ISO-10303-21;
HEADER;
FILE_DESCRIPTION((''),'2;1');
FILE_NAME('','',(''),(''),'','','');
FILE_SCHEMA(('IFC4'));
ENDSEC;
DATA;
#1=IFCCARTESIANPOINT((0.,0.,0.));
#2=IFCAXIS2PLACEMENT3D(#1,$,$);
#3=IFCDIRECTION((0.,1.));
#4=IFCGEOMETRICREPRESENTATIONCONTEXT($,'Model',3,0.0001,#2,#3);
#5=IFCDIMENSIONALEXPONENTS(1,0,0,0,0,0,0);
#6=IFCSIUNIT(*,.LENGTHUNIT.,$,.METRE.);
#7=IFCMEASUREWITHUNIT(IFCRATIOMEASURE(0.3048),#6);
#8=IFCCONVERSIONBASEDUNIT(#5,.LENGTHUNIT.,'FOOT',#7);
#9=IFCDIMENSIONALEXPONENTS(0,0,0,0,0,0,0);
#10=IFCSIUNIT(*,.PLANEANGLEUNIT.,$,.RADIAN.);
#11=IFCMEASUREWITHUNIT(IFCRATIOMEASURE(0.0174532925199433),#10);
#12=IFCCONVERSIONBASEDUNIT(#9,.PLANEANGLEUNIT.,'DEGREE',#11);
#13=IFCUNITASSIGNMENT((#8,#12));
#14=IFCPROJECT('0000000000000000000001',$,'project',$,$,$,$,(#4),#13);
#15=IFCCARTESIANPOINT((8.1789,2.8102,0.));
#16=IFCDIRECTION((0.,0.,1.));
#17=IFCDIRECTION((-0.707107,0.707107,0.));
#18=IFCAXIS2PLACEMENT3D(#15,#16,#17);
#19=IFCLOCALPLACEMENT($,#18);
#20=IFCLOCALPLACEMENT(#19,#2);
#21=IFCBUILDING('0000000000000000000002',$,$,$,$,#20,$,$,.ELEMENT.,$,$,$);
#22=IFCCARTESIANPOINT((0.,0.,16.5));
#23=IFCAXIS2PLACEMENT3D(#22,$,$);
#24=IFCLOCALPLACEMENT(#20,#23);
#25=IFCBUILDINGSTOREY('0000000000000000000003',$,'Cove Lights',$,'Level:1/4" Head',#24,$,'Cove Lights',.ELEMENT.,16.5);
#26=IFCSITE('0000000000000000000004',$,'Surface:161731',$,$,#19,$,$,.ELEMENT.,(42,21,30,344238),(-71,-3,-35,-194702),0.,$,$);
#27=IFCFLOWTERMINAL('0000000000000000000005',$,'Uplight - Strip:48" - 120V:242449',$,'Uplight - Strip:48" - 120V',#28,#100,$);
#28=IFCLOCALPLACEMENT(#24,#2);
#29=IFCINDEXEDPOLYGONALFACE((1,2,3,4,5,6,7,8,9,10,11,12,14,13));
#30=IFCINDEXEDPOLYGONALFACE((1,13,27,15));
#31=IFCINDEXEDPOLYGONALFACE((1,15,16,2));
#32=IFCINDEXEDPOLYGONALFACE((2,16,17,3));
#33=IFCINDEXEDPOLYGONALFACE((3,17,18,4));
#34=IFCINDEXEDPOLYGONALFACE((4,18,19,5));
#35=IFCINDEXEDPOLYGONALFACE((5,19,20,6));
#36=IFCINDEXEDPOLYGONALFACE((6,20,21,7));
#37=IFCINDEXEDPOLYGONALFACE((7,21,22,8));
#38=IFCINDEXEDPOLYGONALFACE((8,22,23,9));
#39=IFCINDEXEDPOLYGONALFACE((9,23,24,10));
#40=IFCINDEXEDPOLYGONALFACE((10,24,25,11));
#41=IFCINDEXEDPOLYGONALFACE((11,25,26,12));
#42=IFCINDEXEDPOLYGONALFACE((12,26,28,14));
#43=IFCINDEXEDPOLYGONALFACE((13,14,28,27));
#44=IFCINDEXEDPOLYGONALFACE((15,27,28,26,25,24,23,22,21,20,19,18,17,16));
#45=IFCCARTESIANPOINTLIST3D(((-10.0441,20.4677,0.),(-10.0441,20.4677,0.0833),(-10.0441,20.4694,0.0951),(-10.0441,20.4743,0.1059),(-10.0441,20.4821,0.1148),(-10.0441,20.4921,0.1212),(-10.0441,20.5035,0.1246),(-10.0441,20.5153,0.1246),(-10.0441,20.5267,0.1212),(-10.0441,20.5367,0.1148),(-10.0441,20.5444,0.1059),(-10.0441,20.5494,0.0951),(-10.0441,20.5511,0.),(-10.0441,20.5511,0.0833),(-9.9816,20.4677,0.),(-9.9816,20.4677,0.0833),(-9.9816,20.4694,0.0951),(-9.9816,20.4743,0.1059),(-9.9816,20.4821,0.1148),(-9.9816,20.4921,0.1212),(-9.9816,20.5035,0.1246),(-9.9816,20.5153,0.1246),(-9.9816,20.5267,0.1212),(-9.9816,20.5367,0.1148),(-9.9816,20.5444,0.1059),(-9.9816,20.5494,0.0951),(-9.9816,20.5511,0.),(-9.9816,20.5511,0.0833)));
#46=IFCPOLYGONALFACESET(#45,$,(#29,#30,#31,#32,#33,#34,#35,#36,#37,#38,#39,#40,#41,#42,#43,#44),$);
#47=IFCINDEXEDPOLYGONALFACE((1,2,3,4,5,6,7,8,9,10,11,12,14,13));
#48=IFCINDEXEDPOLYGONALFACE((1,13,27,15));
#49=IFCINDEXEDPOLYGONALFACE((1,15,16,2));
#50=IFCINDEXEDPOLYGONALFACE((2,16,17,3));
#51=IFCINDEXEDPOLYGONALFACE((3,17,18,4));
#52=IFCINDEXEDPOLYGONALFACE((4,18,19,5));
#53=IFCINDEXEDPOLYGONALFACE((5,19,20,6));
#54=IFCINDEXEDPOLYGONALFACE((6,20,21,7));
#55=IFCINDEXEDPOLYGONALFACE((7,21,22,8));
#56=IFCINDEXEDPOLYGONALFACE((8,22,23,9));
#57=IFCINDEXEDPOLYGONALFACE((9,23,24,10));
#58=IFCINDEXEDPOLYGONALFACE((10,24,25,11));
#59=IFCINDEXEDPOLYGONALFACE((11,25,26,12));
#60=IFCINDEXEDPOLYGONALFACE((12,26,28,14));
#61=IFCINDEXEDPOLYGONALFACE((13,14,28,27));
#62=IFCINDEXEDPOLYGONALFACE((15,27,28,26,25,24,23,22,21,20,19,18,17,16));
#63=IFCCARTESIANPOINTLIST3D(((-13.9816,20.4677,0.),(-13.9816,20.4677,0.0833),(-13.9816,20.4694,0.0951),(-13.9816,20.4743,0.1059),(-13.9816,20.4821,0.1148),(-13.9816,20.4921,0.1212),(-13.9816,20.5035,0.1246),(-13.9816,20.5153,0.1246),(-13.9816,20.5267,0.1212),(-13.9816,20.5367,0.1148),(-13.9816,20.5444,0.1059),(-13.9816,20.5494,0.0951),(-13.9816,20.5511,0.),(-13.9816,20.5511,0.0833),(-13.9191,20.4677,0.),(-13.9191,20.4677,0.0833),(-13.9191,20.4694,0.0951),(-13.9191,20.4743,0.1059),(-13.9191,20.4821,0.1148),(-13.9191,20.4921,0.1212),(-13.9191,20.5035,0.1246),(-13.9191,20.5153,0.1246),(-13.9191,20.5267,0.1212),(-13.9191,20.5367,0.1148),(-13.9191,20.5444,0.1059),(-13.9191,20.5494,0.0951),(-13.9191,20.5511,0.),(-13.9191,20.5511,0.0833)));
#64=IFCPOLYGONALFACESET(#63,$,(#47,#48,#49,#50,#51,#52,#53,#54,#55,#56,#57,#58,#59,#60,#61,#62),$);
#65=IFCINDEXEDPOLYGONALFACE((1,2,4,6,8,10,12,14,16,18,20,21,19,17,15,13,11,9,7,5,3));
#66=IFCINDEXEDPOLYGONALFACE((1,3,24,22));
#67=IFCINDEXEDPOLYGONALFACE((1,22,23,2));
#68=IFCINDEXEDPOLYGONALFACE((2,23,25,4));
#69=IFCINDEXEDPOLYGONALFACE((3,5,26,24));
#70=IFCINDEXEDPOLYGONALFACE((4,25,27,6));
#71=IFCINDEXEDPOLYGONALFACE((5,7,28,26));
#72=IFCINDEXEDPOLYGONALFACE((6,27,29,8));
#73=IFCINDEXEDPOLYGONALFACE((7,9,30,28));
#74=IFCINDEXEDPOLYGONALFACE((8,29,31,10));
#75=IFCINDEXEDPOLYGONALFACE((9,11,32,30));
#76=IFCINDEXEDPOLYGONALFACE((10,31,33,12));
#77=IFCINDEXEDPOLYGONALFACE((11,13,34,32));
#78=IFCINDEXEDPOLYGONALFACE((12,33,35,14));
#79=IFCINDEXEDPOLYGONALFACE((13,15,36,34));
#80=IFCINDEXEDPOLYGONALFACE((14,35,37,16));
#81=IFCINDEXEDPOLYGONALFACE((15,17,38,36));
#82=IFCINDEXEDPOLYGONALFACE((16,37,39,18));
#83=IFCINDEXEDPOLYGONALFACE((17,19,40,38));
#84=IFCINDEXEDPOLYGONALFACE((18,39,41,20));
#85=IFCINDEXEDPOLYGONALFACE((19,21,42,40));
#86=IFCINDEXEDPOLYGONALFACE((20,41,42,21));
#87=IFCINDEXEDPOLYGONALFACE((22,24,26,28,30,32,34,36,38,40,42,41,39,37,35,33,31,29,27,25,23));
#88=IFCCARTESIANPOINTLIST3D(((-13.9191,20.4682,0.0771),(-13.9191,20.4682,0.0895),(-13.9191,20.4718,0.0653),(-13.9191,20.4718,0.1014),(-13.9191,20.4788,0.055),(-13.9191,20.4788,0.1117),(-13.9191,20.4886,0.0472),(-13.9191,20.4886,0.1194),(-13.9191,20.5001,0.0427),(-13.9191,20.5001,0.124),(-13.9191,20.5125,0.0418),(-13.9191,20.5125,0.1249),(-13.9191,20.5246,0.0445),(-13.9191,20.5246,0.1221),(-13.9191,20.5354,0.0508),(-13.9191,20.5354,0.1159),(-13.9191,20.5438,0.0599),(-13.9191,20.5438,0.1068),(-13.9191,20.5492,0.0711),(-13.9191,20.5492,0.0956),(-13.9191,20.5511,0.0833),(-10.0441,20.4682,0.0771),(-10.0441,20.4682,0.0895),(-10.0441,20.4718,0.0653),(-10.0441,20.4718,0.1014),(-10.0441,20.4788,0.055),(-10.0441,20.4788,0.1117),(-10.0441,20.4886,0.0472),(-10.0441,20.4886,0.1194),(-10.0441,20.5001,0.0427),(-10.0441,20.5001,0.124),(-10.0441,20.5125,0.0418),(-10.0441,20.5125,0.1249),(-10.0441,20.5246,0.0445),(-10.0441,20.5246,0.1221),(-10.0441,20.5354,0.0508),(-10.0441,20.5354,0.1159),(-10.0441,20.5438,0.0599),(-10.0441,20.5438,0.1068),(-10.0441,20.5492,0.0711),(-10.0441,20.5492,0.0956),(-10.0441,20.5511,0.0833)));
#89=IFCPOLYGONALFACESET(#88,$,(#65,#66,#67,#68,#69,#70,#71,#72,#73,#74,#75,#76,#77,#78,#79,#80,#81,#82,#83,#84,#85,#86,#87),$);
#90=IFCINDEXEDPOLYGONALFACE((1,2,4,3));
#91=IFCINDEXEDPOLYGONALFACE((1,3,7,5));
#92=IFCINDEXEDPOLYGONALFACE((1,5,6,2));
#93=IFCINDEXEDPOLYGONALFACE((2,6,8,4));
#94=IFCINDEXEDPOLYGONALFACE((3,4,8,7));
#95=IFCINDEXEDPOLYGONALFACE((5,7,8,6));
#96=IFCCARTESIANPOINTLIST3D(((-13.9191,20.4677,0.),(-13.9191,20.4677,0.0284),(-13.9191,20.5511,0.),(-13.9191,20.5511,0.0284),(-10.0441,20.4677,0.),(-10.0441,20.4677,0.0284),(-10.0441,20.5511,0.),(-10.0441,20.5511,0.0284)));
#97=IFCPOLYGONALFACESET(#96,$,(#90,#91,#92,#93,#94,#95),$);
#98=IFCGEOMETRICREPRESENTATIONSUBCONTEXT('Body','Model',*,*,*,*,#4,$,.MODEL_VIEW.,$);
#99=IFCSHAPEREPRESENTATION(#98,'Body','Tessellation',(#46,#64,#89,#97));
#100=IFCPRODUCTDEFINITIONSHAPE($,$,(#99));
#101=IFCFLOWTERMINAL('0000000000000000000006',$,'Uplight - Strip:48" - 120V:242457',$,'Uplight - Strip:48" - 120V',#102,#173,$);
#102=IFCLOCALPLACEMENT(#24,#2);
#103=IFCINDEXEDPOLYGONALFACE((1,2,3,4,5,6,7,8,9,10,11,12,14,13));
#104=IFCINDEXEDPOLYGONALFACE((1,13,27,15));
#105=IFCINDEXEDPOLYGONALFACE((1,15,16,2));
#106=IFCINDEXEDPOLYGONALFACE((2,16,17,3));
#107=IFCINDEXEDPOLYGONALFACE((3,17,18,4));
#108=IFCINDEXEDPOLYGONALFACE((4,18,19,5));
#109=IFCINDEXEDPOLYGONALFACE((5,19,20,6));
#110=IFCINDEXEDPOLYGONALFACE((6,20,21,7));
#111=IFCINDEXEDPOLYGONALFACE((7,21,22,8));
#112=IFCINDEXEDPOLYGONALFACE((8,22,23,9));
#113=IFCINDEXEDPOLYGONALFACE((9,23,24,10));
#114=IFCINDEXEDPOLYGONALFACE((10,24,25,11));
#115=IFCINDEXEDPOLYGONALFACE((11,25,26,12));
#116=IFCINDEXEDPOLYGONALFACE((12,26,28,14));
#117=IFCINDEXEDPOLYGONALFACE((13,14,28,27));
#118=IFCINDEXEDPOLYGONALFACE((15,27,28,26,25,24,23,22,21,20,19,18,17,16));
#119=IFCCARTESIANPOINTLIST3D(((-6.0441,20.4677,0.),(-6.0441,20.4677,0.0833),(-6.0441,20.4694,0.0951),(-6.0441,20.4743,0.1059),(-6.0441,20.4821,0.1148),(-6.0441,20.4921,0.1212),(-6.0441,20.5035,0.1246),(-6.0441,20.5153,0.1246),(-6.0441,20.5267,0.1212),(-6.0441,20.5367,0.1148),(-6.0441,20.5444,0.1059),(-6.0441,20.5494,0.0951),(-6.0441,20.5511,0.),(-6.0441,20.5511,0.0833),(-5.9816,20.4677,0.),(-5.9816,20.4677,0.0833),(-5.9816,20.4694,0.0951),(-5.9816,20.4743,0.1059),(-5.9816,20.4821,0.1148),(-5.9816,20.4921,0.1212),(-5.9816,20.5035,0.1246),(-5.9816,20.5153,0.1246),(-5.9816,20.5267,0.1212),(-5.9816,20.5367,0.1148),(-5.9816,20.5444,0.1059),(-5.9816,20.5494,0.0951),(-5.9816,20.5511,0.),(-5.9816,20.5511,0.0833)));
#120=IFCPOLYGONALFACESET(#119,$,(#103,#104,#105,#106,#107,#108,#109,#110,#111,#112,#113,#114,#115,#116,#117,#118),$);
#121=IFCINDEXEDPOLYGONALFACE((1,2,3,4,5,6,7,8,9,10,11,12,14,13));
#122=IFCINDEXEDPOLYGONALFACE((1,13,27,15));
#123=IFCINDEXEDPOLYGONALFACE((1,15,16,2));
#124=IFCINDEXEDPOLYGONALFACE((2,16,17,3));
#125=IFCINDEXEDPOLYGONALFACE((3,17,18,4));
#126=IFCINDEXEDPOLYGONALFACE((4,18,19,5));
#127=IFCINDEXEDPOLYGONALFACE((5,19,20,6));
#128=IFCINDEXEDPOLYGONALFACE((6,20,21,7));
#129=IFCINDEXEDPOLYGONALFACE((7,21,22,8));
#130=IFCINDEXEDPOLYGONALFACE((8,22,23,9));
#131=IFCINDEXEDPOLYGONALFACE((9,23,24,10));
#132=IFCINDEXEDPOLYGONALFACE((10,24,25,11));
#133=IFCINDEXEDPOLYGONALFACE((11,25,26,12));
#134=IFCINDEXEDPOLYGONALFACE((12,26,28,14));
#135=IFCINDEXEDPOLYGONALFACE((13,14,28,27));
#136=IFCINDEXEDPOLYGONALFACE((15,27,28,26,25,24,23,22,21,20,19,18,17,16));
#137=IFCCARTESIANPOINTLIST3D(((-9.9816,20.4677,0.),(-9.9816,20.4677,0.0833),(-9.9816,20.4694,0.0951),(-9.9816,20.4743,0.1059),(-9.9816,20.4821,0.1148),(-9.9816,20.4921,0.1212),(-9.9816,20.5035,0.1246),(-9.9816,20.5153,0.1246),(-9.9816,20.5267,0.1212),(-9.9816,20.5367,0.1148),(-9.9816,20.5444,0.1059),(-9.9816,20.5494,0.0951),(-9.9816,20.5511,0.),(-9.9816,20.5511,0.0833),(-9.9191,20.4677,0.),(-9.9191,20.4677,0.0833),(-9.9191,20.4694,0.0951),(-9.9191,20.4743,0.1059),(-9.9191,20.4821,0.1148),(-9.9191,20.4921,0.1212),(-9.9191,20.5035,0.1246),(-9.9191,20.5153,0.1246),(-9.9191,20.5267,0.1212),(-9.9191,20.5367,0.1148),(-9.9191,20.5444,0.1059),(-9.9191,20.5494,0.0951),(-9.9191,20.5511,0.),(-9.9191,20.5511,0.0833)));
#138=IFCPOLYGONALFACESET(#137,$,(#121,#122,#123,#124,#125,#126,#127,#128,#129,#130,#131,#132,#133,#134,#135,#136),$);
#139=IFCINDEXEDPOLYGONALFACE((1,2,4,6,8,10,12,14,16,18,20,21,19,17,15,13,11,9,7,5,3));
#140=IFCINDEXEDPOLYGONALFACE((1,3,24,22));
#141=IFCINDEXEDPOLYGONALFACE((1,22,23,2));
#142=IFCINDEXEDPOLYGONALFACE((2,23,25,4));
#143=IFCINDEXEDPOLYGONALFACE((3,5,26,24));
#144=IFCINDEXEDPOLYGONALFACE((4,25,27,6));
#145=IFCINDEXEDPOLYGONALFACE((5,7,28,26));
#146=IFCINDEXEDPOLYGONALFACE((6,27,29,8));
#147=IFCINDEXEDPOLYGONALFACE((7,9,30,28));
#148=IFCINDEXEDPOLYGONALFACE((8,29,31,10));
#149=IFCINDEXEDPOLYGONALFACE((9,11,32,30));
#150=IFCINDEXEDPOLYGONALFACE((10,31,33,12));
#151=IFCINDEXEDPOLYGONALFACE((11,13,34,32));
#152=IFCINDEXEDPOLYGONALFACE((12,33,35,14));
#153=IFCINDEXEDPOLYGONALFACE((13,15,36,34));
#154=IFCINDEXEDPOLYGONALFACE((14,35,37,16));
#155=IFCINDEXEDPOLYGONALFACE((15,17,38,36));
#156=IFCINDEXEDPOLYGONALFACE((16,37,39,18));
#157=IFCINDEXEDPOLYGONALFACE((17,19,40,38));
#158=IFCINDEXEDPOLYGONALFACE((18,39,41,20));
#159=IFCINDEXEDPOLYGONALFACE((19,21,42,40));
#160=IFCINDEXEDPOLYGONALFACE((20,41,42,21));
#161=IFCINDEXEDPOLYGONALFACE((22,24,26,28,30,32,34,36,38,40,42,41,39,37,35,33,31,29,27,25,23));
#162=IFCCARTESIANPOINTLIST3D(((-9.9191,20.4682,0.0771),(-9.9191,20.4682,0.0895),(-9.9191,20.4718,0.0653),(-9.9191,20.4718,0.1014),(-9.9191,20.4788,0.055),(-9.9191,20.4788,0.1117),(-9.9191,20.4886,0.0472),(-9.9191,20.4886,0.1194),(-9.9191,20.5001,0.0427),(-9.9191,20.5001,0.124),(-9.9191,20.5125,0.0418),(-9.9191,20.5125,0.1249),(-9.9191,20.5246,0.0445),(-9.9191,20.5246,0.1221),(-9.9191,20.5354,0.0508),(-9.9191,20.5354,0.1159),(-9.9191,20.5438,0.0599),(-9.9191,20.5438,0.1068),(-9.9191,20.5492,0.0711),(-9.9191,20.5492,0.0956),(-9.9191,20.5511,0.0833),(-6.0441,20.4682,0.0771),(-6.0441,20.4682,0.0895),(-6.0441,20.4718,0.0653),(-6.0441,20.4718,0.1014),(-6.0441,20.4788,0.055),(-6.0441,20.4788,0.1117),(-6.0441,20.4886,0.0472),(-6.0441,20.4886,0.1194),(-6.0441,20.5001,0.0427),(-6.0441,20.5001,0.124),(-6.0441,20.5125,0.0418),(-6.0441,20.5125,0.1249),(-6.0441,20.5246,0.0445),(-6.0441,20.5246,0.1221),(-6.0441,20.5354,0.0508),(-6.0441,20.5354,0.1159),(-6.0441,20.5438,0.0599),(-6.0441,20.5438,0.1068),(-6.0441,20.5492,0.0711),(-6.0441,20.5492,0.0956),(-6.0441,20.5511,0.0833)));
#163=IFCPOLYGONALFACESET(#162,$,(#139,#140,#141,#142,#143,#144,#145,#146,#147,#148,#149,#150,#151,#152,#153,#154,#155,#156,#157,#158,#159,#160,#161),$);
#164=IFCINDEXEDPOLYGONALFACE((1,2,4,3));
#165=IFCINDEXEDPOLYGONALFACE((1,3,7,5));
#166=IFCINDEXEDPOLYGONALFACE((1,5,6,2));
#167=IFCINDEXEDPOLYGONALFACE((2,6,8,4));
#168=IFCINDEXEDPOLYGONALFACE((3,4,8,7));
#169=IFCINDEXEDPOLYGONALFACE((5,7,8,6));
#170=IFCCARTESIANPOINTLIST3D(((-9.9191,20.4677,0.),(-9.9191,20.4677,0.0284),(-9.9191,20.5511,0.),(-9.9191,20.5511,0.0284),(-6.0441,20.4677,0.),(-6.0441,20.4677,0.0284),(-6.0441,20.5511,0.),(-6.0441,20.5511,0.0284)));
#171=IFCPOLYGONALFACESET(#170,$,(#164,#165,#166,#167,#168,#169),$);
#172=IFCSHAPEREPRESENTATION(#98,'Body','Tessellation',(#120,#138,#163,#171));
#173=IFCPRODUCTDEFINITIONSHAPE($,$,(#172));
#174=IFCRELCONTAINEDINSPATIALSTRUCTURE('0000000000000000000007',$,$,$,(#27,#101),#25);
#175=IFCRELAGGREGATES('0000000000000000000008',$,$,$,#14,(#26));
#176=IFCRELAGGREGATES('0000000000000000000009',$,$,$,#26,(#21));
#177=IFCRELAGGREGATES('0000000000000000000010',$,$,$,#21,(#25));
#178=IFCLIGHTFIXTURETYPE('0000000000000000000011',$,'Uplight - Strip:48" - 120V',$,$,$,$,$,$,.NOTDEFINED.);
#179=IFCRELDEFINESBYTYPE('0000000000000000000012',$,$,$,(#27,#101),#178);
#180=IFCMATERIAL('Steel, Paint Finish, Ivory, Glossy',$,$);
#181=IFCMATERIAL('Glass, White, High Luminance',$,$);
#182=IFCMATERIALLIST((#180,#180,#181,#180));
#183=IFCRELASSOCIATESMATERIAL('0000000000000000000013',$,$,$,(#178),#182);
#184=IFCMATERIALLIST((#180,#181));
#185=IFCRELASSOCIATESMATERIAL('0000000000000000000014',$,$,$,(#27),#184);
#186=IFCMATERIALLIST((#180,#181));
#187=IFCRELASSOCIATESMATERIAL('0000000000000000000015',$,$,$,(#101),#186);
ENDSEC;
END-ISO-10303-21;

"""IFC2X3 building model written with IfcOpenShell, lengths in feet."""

from ifc_helpers import new_model, entity, si_unit, converted_unit, direction, frame, frame_2d, origin, origin_2d_with_axis, place, context, subcontext, project, spatial, polyline, circle_curve, parameter, trimmed, segment, composite_curve, rectangle, circle, outline, extrude, source, transform, mapped, material, material_list, type_object, type_shapes, element, save


model = new_model("IFC2X3")

# Units and contexts
model_context = context("Model", 3, precision=0.0001, world=origin(), true_north=direction((0.0, 1.0)))
body_context = subcontext(model_context, "Body", "Model", "MODEL_VIEW")
ifc_project = project(units=[converted_unit("LENGTHUNIT", "FOOT", entity("IfcRatioMeasure", 0.3048), si_unit("LENGTHUNIT", "METRE"), dimensions=[1, 0, 0, 0, 0, 0, 0]), converted_unit("PLANEANGLEUNIT", "DEGREE", entity("IfcRatioMeasure", 0.0174532925199433), si_unit("PLANEANGLEUNIT", "RADIAN"), dimensions=[0, 0, 0, 0, 0, 0, 0])], contexts=[model_context])

# Site, building, storey
site_placement = place(None, frame((8.1789, 2.8102, 0.0), z_axis=(0.0, 0.0, 1.0), x_axis=(-0.707107, 0.707107, 0.0)))
site = spatial("IfcSite", under=ifc_project, at=site_placement, Name="Surface:161731", CompositionType="ELEMENT", RefLatitude=(42, 21, 30, 344238), RefLongitude=(-71, -3, -35, -194702), RefElevation=0.0)
building_placement = place(site_placement, origin())
building = spatial("IfcBuilding", under=site, at=building_placement, CompositionType="ELEMENT")
storey_placement = place(building_placement, frame((0.0, 0.0, 16.5)))
storey = spatial("IfcBuildingStorey", under=building, at=storey_placement, Name="Cove Lights", ObjectType="Level:1/4\" Head", LongName="Cove Lights", CompositionType="ELEMENT", Elevation=16.5)

# Flow terminals
ifc_material_1 = material(Name="Steel, Paint Finish, Ivory, Glossy")
ifc_material_2 = material(Name="Glass, White, High Luminance")
ifc_material_list_1 = material_list([ifc_material_1, ifc_material_1, ifc_material_2, ifc_material_1])
light_fixture_type_1 = type_object("IfcLightFixtureType", Name="Uplight - Strip:48\" - 120V", PredefinedType="NOTDEFINED", material=ifc_material_list_1)
shared_shape_1 = source(origin(), body_context, "Body", "SweptSolid", [
    extrude(outline(composite_curve([segment(polyline([(-0.0417, -0.0417), (0.0417, -0.0417)]), True, "CONTINUOUS"), segment(trimmed(circle_curve(frame_2d((0.0417, 0.0), x_axis=(0.0, -1.0)), 0.0417), [parameter(0.0)], [parameter(180.0)], True, "PARAMETER"), True, "CONTINUOUS"), segment(polyline([(0.0417, 0.0417), (-0.0417, 0.0417)]), True, "CONTINUOUS"), segment(polyline([(-0.0417, 0.0417), (-0.0417, -0.0417)]), True, "CONTINUOUS")], self_intersect=False)), frame((1.9375, 0.0, 0.0417), z_axis=(1.0, 0.0, 0.0), x_axis=(0.0, 0.0, 1.0)), (0.0, 0.0, 1.0), 0.0625),
    extrude(outline(composite_curve([segment(polyline([(-0.0417, -0.0417), (0.0417, -0.0417)]), True, "CONTINUOUS"), segment(polyline([(0.0417, -0.0417), (0.0417, 0.0417)]), True, "CONTINUOUS"), segment(trimmed(circle_curve(frame_2d((0.0, 0.0417), x_axis=(0.0, 1.0)), 0.0417), [parameter(270.0)], [parameter(90.0)], True, "PARAMETER"), True, "CONTINUOUS"), segment(polyline([(-0.0417, 0.0417), (-0.0417, -0.0417)]), True, "CONTINUOUS")], self_intersect=False)), frame((-2.0, 0.0, 0.0417), z_axis=(1.0, 0.0, 0.0), x_axis=(0.0, 1.0, 0.0)), (0.0, 0.0, 1.0), 0.0625),
    extrude(circle(Radius=0.0417, at=frame_2d((0.0, 0.0), x_axis=(1.0, 0.0))), frame((-1.9375, 0.0, 0.0833), z_axis=(1.0, 0.0, 0.0), x_axis=(0.0, 1.0, 0.0)), (0.0, 0.0, 1.0), 3.875),
    extrude(rectangle(XDim=3.875, YDim=0.0833, at=origin_2d_with_axis()), frame((0.0, 0.0, 0.0), z_axis=(0.0, 0.0, 1.0), x_axis=(-1.0, 0.0, 0.0)), (0.0, 0.0, 1.0), 0.0284),
])
type_shapes(light_fixture_type_1, [shared_shape_1])
ifc_material_list_2 = material_list([ifc_material_1, ifc_material_2])
flow_terminal_1_placement = place(storey_placement, frame((-11.9816, 20.5094, 0.0)))
element("IfcFlowTerminal", 1, at=flow_terminal_1_placement, inside=storey, type_object=light_fixture_type_1, material=ifc_material_list_2, Name="Uplight - Strip:48\" - 120V:242449", ObjectType="Uplight - Strip:48\" - 120V", context=body_context, shape_type="MappedRepresentation", body=[
    mapped(shared_shape_1, transform((0.0, 0.0, 0.0), scale=1.0)),
])
ifc_material_list_3 = material_list([ifc_material_1, ifc_material_2])
flow_terminal_2_placement = place(storey_placement, frame((-7.9816, 20.5094, 0.0)))
element("IfcFlowTerminal", 2, at=flow_terminal_2_placement, inside=storey, type_object=light_fixture_type_1, material=ifc_material_list_3, Name="Uplight - Strip:48\" - 120V:242457", ObjectType="Uplight - Strip:48\" - 120V", context=body_context, shape_type="MappedRepresentation", body=[
    mapped(shared_shape_1, transform((0.0, 0.0, 0.0), scale=1.0)),
])

save(model, "model.ifc")
